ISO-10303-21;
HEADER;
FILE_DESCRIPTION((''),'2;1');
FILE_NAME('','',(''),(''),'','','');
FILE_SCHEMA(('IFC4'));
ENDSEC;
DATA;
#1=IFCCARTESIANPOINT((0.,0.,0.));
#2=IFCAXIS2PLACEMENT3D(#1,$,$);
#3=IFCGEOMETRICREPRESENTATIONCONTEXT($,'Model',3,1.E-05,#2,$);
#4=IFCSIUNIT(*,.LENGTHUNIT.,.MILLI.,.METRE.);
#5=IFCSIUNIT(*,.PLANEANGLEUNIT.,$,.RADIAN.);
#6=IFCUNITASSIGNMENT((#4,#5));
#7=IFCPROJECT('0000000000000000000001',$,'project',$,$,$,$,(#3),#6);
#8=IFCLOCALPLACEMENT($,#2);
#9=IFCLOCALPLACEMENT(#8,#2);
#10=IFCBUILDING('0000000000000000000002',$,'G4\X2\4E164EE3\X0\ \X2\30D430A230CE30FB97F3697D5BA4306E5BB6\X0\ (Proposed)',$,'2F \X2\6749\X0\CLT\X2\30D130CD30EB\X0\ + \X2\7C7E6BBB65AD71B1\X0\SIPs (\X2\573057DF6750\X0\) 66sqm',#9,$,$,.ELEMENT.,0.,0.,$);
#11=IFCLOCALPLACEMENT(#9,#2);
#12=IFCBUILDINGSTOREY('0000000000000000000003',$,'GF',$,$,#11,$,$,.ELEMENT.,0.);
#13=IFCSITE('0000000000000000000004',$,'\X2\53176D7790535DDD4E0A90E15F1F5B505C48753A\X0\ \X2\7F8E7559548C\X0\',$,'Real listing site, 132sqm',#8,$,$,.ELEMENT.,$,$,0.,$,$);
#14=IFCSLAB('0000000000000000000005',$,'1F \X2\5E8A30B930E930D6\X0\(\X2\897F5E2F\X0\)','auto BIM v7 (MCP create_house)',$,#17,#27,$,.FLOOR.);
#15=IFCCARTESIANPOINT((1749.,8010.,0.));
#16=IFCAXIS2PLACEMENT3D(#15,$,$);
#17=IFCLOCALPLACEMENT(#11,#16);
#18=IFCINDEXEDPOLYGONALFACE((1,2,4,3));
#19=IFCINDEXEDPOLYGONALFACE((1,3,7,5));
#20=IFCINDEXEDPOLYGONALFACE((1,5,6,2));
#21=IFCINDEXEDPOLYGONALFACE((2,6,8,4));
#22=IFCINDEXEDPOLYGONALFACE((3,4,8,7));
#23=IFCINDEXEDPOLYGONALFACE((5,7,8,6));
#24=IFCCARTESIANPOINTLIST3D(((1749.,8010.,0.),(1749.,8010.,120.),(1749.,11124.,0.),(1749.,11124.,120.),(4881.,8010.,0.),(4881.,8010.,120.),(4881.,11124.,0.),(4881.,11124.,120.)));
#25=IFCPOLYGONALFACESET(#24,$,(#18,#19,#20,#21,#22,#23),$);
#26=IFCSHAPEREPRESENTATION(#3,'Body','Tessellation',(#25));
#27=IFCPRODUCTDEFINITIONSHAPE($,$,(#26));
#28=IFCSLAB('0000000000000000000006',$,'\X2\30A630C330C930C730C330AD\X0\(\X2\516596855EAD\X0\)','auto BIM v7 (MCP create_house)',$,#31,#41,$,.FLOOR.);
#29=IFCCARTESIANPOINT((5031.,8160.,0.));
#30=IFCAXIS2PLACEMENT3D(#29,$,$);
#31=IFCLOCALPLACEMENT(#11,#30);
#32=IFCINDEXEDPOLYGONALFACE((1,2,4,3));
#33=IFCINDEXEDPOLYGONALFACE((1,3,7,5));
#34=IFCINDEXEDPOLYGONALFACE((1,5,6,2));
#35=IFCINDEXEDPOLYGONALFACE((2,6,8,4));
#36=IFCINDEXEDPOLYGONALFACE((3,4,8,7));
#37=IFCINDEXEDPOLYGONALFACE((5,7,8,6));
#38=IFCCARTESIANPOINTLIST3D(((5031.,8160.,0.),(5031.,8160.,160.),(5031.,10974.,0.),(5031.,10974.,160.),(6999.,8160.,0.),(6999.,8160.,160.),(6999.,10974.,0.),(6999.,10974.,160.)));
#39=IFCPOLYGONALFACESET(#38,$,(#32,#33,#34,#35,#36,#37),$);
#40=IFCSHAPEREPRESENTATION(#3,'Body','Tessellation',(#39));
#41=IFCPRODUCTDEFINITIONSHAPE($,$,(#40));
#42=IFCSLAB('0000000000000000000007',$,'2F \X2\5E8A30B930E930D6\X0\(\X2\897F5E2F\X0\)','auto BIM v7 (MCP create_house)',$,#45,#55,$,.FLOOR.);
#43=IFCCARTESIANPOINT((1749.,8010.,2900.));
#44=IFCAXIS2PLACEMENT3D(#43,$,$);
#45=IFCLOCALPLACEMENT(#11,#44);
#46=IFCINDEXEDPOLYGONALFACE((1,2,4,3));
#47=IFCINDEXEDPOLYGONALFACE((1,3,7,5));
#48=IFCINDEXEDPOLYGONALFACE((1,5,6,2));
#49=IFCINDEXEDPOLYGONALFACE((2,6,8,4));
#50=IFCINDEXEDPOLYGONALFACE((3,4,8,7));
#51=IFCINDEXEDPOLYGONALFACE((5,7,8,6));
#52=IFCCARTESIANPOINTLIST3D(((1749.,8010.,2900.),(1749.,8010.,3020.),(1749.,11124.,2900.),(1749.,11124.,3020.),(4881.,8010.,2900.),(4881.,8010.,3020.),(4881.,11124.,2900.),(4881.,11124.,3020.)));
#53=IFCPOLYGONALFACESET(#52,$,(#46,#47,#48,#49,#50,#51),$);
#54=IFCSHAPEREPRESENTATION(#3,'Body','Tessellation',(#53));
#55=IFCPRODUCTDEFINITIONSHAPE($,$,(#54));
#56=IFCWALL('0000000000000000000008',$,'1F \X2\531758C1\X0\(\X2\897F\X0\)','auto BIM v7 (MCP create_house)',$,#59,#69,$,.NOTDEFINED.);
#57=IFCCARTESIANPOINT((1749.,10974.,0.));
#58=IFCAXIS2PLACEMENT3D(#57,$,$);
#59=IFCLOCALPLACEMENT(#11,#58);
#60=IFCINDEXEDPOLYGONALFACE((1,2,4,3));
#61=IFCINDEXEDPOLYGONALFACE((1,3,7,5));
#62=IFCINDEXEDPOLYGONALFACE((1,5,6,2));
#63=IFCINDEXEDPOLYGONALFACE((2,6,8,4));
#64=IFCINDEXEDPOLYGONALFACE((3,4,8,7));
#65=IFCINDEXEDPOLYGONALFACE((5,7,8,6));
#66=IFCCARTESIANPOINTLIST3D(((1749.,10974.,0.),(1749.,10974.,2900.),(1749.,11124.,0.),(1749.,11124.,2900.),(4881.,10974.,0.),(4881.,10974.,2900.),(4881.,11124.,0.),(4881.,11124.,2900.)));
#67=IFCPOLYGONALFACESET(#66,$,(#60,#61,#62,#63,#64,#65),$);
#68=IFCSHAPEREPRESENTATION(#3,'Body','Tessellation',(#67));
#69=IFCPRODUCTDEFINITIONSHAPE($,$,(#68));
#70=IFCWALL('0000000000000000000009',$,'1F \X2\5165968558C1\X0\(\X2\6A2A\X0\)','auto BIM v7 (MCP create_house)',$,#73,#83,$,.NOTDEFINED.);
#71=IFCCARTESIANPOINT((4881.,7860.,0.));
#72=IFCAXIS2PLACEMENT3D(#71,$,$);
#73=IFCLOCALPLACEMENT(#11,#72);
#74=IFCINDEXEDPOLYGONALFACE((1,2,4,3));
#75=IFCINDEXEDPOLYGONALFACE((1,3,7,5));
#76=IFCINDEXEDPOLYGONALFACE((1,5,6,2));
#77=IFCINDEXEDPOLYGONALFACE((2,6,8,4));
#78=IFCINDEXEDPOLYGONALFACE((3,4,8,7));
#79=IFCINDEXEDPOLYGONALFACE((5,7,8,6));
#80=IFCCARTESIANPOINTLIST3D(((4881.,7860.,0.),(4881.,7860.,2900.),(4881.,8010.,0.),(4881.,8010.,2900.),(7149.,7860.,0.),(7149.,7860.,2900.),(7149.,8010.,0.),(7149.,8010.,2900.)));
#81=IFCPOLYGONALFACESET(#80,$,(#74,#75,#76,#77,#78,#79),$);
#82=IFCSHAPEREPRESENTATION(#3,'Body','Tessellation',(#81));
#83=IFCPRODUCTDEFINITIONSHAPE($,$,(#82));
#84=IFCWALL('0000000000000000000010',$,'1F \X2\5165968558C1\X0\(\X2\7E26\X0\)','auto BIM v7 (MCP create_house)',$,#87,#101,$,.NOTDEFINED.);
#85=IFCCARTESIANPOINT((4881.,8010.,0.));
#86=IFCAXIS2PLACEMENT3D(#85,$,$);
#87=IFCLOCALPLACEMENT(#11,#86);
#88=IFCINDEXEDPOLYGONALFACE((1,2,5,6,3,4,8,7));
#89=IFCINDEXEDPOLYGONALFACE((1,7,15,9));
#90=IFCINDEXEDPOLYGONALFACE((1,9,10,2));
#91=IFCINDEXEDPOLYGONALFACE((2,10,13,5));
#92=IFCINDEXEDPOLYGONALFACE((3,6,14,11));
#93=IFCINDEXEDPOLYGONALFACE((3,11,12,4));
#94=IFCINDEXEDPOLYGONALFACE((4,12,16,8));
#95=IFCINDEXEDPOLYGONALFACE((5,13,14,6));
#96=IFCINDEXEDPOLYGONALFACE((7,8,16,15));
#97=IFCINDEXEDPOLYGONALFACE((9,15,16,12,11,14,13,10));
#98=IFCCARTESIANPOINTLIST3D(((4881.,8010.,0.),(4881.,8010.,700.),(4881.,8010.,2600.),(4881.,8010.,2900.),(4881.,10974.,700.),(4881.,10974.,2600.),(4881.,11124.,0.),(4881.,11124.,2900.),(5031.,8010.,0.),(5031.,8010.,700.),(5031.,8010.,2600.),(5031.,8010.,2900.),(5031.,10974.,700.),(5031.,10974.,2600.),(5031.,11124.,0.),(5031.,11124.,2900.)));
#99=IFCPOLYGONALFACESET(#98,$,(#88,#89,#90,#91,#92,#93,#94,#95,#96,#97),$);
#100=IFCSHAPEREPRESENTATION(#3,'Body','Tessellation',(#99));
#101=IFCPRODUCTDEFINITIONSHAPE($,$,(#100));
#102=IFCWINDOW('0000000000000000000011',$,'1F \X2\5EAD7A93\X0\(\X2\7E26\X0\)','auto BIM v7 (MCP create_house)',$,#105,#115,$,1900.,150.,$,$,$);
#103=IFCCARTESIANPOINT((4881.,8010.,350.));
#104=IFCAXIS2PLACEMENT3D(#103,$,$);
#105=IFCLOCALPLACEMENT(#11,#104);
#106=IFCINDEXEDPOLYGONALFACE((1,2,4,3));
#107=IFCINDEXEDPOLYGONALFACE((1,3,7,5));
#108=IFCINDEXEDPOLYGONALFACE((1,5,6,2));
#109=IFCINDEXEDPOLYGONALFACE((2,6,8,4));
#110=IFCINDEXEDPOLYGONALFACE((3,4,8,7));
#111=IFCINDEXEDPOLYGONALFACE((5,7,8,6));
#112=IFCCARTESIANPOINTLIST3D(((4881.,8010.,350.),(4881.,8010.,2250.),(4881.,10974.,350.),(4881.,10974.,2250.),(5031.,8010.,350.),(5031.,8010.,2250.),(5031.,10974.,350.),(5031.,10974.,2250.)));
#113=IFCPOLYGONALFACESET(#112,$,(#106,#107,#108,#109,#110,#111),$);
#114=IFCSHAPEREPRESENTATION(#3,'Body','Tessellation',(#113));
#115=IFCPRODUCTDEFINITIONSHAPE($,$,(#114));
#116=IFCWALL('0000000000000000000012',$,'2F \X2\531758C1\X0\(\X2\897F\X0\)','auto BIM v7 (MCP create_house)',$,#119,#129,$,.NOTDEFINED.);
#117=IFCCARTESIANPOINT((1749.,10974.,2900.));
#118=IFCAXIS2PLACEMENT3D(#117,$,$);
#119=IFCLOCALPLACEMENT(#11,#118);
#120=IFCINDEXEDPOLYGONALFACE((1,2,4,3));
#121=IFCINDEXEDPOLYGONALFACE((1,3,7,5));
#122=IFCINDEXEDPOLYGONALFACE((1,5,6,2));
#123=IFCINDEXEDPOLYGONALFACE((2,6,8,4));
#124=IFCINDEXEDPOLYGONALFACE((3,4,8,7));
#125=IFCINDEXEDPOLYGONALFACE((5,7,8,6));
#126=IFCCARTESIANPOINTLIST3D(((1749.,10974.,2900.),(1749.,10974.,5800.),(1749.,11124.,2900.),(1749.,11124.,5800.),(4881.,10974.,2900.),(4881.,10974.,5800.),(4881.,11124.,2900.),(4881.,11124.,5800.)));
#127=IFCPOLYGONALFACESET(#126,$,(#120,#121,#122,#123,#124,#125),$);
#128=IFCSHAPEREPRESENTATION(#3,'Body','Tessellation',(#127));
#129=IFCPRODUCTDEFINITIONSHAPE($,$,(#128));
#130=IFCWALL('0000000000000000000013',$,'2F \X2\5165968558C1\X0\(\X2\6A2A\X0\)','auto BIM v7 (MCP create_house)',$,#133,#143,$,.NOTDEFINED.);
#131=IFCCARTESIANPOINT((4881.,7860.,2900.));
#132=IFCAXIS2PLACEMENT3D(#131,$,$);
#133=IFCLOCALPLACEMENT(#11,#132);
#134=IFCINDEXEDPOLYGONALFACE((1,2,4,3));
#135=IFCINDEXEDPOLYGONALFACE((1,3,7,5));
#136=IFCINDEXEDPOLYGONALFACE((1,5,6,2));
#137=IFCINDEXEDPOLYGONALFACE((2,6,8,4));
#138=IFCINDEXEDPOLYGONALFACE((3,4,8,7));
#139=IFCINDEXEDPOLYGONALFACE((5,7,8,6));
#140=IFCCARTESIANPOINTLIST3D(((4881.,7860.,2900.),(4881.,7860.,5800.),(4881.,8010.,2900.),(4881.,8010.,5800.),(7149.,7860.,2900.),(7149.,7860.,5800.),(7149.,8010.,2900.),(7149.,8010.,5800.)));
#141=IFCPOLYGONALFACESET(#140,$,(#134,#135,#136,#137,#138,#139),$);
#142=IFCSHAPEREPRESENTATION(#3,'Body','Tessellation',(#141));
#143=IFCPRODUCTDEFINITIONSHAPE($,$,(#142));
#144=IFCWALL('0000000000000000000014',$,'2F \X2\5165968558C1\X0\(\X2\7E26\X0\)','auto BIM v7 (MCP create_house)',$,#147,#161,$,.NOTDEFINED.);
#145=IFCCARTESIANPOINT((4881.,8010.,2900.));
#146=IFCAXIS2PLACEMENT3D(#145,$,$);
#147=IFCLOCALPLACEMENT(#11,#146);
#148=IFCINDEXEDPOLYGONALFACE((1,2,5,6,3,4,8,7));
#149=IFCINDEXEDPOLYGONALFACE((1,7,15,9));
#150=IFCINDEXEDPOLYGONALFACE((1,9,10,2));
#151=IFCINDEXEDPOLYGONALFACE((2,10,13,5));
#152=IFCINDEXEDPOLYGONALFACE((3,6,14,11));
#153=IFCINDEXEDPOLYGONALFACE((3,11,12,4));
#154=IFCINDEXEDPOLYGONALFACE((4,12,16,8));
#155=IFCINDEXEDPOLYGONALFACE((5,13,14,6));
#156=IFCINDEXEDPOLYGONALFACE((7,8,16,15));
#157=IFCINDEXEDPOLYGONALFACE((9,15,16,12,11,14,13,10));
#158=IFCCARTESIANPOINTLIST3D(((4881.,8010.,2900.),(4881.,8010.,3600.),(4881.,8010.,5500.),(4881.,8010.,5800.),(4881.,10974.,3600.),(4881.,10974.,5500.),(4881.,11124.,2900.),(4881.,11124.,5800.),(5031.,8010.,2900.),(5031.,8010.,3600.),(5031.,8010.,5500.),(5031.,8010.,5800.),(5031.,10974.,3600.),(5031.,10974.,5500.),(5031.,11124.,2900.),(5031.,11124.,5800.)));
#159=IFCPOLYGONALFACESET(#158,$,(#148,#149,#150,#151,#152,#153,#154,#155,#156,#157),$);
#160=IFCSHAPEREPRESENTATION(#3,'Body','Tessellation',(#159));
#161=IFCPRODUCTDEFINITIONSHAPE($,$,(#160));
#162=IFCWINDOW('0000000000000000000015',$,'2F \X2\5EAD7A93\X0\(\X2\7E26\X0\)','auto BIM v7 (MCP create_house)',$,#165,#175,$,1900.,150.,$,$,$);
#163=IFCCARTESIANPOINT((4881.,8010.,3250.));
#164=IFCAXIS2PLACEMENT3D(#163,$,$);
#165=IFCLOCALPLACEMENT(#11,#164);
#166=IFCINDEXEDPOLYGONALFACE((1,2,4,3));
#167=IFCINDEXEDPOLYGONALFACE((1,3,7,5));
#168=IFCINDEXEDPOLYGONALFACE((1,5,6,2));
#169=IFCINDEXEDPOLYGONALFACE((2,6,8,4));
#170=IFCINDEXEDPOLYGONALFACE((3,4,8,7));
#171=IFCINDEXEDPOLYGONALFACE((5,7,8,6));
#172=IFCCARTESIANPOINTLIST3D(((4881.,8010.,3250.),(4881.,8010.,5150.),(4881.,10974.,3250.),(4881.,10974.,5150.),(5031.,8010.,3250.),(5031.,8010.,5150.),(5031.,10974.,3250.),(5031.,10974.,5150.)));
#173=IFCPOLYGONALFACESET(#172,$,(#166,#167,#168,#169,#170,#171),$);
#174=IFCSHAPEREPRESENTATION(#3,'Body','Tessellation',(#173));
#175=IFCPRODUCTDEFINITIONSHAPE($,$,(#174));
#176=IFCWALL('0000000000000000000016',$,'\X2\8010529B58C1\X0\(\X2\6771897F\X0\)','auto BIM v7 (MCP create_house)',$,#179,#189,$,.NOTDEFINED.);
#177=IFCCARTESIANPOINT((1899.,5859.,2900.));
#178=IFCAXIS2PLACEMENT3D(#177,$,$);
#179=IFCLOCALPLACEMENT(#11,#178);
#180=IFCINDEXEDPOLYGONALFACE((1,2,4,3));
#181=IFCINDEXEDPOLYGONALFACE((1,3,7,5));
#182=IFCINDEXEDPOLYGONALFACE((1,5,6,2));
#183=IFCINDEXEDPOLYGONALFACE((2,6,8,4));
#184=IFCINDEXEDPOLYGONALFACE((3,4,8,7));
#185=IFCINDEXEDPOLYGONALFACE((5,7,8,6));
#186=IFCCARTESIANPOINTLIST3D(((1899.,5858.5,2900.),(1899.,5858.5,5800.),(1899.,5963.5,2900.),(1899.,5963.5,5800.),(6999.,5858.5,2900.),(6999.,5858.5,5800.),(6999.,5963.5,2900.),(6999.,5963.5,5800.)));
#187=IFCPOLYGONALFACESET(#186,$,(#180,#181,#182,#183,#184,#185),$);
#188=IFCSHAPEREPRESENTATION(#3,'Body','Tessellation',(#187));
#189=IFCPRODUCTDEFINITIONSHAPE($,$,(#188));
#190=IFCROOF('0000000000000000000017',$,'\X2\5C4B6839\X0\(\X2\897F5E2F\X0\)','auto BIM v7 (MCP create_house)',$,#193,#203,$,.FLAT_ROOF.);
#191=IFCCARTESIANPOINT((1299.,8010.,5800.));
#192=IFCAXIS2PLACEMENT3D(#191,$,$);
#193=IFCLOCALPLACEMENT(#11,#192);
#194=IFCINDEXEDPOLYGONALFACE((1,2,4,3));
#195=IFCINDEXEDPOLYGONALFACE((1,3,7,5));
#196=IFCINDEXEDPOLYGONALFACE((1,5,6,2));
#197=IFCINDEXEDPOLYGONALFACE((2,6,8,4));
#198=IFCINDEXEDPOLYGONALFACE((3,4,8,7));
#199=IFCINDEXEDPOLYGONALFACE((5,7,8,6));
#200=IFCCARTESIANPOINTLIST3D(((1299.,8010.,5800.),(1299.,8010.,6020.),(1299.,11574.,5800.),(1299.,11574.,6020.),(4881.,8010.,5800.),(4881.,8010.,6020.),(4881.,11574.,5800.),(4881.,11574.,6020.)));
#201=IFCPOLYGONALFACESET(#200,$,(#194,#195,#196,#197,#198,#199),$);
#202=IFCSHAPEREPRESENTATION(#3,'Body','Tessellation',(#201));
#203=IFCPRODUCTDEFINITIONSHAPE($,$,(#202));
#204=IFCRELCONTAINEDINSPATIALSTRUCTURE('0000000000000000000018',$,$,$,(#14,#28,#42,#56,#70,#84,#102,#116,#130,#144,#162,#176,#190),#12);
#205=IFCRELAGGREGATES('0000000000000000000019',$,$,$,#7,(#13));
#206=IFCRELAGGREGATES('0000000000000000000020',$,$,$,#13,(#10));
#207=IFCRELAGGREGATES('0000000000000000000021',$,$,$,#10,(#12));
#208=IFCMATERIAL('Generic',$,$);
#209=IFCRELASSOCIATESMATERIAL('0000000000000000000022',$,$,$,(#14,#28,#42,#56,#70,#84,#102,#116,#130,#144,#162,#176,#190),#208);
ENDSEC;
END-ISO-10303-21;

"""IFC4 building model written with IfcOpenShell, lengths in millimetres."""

from ifc_helpers import new_model, si_unit, frame, frame_2d, origin, place, context, project, spatial, rectangle, extrude, material, element, fill, save


model = new_model("IFC4")

# Units and contexts
model_context = context("Model", 3, precision=1e-05, world=origin())
ifc_project = project(units=[si_unit("LENGTHUNIT", "METRE", prefix="MILLI"), si_unit("PLANEANGLEUNIT", "RADIAN")], contexts=[model_context])

# Site, building, storey
site_placement = place(None, origin())
site = spatial("IfcSite", under=ifc_project, at=site_placement, Name="北海道川上郡弟子屈町 美留和", ObjectType="Real listing site, 132sqm", CompositionType="ELEMENT", RefElevation=0.0)
building_placement = place(site_placement, origin())
building = spatial("IfcBuilding", under=site, at=building_placement, Name="G4世代 ピアノ・音楽室の家 (Proposed)", ObjectType="2F 杉CLTパネル + 籾殻断熱SIPs (地域材) 66sqm", CompositionType="ELEMENT", ElevationOfRefHeight=0.0, ElevationOfTerrain=0.0)
storey_placement = place(building_placement, origin())
storey = spatial("IfcBuildingStorey", under=building, at=storey_placement, Name="GF", CompositionType="ELEMENT", Elevation=0.0)

# Slabs
ifc_material = material(Name="Generic")
slab_1_placement = place(storey_placement, frame((1749.0, 8010.0, 0.0)))
element("IfcSlab", 1, at=slab_1_placement, inside=storey, material=ifc_material, Name="1F 床スラブ(西帯)", Description="auto BIM v7 (MCP create_house)", PredefinedType="FLOOR", context=model_context, shape_type="SweptSolid", body=[
    extrude(rectangle(XDim=3132.0, YDim=3114.0, at=frame_2d((1566.0, 1557.0))), frame((1749.0, 8010.0, 0.0)), (0.0, 0.0, 1.0), 120.0),
])
slab_2_placement = place(storey_placement, frame((5031.0, 8160.0, 0.0)))
element("IfcSlab", 2, at=slab_2_placement, inside=storey, material=ifc_material, Name="ウッドデッキ(入隅庭)", Description="auto BIM v7 (MCP create_house)", PredefinedType="FLOOR", context=model_context, shape_type="SweptSolid", body=[
    extrude(rectangle(XDim=1968.0, YDim=2814.0, at=frame_2d((984.0, 1407.0))), frame((5031.0, 8160.0, 0.0)), (0.0, 0.0, 1.0), 160.0),
])
slab_3_placement = place(storey_placement, frame((1749.0, 8010.0, 2900.0)))
element("IfcSlab", 3, at=slab_3_placement, inside=storey, material=ifc_material, Name="2F 床スラブ(西帯)", Description="auto BIM v7 (MCP create_house)", PredefinedType="FLOOR", context=model_context, shape_type="SweptSolid", body=[
    extrude(rectangle(XDim=3132.0, YDim=3114.0, at=frame_2d((1566.0, 1557.0))), frame((1749.0, 8010.0, 2900.0)), (0.0, 0.0, 1.0), 120.0),
])

# Walls
wall_1_placement = place(storey_placement, frame((1749.0, 10974.0, 0.0)))
element("IfcWall", 4, at=wall_1_placement, inside=storey, material=ifc_material, Name="1F 北壁(西)", Description="auto BIM v7 (MCP create_house)", PredefinedType="NOTDEFINED", context=model_context, shape_type="SweptSolid", body=[
    extrude(rectangle(XDim=3132.0, YDim=150.0, at=frame_2d((1566.0, 75.0))), frame((1749.0, 10974.0, 0.0)), (0.0, 0.0, 1.0), 2900.0),
])
wall_2_placement = place(storey_placement, frame((4881.0, 7860.0, 0.0)))
element("IfcWall", 5, at=wall_2_placement, inside=storey, material=ifc_material, Name="1F 入隅壁(横)", Description="auto BIM v7 (MCP create_house)", PredefinedType="NOTDEFINED", context=model_context, shape_type="SweptSolid", body=[
    extrude(rectangle(XDim=2268.0, YDim=150.0, at=frame_2d((1134.0, 75.0))), frame((4881.0, 7860.0, 0.0)), (0.0, 0.0, 1.0), 2900.0),
])

# Wall, opening, window
wall_3_placement = place(storey_placement, frame((4881.0, 8010.0, 0.0)))
wall_3 = element("IfcWall", 6, at=wall_3_placement, inside=storey, material=ifc_material, Name="1F 入隅壁(縦)", Description="auto BIM v7 (MCP create_house)", PredefinedType="NOTDEFINED", context=model_context, shape_type="SweptSolid", body=[
    extrude(rectangle(XDim=150.0, YDim=3114.0, at=frame_2d((75.0, 1557.0))), frame((4881.0, 8010.0, 0.0)), (0.0, 0.0, 1.0), 2900.0),
])
opening_1_placement = place(storey_placement, frame((4881.0, 8010.0, 350.0)))
opening_1 = element("IfcOpeningElement", 7, at=opening_1_placement, cuts=wall_3, PredefinedType="NOTDEFINED", context=model_context, shape_type="SweptSolid", body=[
    extrude(rectangle(XDim=150.0, YDim=2964.0, at=frame_2d((75.0, 1482.0))), frame((4881.0, 8010.0, 350.0)), (0.0, 0.0, 1.0), 1900.0),
])
window_1_placement = place(storey_placement, frame((4881.0, 8010.0, 350.0)))
window_1 = element("IfcWindow", 8, at=window_1_placement, inside=storey, material=ifc_material, Name="1F 庭窓(縦)", Description="auto BIM v7 (MCP create_house)", OverallHeight=1900.0, OverallWidth=150.0, context=model_context, shape_type="SweptSolid", body=[
    extrude(rectangle(XDim=150.0, YDim=2964.0, at=frame_2d((75.0, 1482.0))), frame((4881.0, 8010.0, 350.0)), (0.0, 0.0, 1.0), 1900.0),
])
fill(opening_1, window_1)

# Walls
wall_4_placement = place(storey_placement, frame((1749.0, 10974.0, 2900.0)))
element("IfcWall", 9, at=wall_4_placement, inside=storey, material=ifc_material, Name="2F 北壁(西)", Description="auto BIM v7 (MCP create_house)", PredefinedType="NOTDEFINED", context=model_context, shape_type="SweptSolid", body=[
    extrude(rectangle(XDim=3132.0, YDim=150.0, at=frame_2d((1566.0, 75.0))), frame((1749.0, 10974.0, 2900.0)), (0.0, 0.0, 1.0), 2900.0),
])
wall_5_placement = place(storey_placement, frame((4881.0, 7860.0, 2900.0)))
element("IfcWall", 10, at=wall_5_placement, inside=storey, material=ifc_material, Name="2F 入隅壁(横)", Description="auto BIM v7 (MCP create_house)", PredefinedType="NOTDEFINED", context=model_context, shape_type="SweptSolid", body=[
    extrude(rectangle(XDim=2268.0, YDim=150.0, at=frame_2d((1134.0, 75.0))), frame((4881.0, 7860.0, 2900.0)), (0.0, 0.0, 1.0), 2900.0),
])

# Wall, opening, window
wall_6_placement = place(storey_placement, frame((4881.0, 8010.0, 2900.0)))
wall_6 = element("IfcWall", 11, at=wall_6_placement, inside=storey, material=ifc_material, Name="2F 入隅壁(縦)", Description="auto BIM v7 (MCP create_house)", PredefinedType="NOTDEFINED", context=model_context, shape_type="SweptSolid", body=[
    extrude(rectangle(XDim=150.0, YDim=3114.0, at=frame_2d((75.0, 1557.0))), frame((4881.0, 8010.0, 2900.0)), (0.0, 0.0, 1.0), 2900.0),
])
opening_2_placement = place(storey_placement, frame((4881.0, 8010.0, 3250.0)))
opening_2 = element("IfcOpeningElement", 12, at=opening_2_placement, cuts=wall_6, PredefinedType="NOTDEFINED", context=model_context, shape_type="SweptSolid", body=[
    extrude(rectangle(XDim=150.0, YDim=2964.0, at=frame_2d((75.0, 1482.0))), frame((4881.0, 8010.0, 3250.0)), (0.0, 0.0, 1.0), 1900.0),
])
window_2_placement = place(storey_placement, frame((4881.0, 8010.0, 3250.0)))
window_2 = element("IfcWindow", 13, at=window_2_placement, inside=storey, material=ifc_material, Name="2F 庭窓(縦)", Description="auto BIM v7 (MCP create_house)", OverallHeight=1900.0, OverallWidth=150.0, context=model_context, shape_type="SweptSolid", body=[
    extrude(rectangle(XDim=150.0, YDim=2964.0, at=frame_2d((75.0, 1482.0))), frame((4881.0, 8010.0, 3250.0)), (0.0, 0.0, 1.0), 1900.0),
])
fill(opening_2, window_2)

# Wall
wall_7_placement = place(storey_placement, frame((1899.0, 5859.0, 2900.0)))
element("IfcWall", 14, at=wall_7_placement, inside=storey, material=ifc_material, Name="耐力壁(東西)", Description="auto BIM v7 (MCP create_house)", PredefinedType="NOTDEFINED", context=model_context, shape_type="SweptSolid", body=[
    extrude(rectangle(XDim=5100.0, YDim=105.0, at=frame_2d((2550.0, 52.0))), frame((1899.0, 5859.0, 2900.0)), (0.0, 0.0, 1.0), 2900.0),
])

# Roof
for number, where, name in (
    (15, (1299.0, 8010.0, 5800.0), "屋根(西帯)"),
):
    element("IfcRoof", number, at=place(storey_placement, frame(where)), inside=storey, material=ifc_material, Name=name, Description="auto BIM v7 (MCP create_house)", PredefinedType="FLAT_ROOF", context=model_context, shape_type="SweptSolid", body=[
        extrude(rectangle(XDim=3582.0, YDim=3564.0, at=frame_2d((1791.0, 1782.0))), frame((1299.0, 8010.0, 5800.0)), (0.0, 0.0, 1.0), 220.0),
    ])

save(model, "model.ifc")
